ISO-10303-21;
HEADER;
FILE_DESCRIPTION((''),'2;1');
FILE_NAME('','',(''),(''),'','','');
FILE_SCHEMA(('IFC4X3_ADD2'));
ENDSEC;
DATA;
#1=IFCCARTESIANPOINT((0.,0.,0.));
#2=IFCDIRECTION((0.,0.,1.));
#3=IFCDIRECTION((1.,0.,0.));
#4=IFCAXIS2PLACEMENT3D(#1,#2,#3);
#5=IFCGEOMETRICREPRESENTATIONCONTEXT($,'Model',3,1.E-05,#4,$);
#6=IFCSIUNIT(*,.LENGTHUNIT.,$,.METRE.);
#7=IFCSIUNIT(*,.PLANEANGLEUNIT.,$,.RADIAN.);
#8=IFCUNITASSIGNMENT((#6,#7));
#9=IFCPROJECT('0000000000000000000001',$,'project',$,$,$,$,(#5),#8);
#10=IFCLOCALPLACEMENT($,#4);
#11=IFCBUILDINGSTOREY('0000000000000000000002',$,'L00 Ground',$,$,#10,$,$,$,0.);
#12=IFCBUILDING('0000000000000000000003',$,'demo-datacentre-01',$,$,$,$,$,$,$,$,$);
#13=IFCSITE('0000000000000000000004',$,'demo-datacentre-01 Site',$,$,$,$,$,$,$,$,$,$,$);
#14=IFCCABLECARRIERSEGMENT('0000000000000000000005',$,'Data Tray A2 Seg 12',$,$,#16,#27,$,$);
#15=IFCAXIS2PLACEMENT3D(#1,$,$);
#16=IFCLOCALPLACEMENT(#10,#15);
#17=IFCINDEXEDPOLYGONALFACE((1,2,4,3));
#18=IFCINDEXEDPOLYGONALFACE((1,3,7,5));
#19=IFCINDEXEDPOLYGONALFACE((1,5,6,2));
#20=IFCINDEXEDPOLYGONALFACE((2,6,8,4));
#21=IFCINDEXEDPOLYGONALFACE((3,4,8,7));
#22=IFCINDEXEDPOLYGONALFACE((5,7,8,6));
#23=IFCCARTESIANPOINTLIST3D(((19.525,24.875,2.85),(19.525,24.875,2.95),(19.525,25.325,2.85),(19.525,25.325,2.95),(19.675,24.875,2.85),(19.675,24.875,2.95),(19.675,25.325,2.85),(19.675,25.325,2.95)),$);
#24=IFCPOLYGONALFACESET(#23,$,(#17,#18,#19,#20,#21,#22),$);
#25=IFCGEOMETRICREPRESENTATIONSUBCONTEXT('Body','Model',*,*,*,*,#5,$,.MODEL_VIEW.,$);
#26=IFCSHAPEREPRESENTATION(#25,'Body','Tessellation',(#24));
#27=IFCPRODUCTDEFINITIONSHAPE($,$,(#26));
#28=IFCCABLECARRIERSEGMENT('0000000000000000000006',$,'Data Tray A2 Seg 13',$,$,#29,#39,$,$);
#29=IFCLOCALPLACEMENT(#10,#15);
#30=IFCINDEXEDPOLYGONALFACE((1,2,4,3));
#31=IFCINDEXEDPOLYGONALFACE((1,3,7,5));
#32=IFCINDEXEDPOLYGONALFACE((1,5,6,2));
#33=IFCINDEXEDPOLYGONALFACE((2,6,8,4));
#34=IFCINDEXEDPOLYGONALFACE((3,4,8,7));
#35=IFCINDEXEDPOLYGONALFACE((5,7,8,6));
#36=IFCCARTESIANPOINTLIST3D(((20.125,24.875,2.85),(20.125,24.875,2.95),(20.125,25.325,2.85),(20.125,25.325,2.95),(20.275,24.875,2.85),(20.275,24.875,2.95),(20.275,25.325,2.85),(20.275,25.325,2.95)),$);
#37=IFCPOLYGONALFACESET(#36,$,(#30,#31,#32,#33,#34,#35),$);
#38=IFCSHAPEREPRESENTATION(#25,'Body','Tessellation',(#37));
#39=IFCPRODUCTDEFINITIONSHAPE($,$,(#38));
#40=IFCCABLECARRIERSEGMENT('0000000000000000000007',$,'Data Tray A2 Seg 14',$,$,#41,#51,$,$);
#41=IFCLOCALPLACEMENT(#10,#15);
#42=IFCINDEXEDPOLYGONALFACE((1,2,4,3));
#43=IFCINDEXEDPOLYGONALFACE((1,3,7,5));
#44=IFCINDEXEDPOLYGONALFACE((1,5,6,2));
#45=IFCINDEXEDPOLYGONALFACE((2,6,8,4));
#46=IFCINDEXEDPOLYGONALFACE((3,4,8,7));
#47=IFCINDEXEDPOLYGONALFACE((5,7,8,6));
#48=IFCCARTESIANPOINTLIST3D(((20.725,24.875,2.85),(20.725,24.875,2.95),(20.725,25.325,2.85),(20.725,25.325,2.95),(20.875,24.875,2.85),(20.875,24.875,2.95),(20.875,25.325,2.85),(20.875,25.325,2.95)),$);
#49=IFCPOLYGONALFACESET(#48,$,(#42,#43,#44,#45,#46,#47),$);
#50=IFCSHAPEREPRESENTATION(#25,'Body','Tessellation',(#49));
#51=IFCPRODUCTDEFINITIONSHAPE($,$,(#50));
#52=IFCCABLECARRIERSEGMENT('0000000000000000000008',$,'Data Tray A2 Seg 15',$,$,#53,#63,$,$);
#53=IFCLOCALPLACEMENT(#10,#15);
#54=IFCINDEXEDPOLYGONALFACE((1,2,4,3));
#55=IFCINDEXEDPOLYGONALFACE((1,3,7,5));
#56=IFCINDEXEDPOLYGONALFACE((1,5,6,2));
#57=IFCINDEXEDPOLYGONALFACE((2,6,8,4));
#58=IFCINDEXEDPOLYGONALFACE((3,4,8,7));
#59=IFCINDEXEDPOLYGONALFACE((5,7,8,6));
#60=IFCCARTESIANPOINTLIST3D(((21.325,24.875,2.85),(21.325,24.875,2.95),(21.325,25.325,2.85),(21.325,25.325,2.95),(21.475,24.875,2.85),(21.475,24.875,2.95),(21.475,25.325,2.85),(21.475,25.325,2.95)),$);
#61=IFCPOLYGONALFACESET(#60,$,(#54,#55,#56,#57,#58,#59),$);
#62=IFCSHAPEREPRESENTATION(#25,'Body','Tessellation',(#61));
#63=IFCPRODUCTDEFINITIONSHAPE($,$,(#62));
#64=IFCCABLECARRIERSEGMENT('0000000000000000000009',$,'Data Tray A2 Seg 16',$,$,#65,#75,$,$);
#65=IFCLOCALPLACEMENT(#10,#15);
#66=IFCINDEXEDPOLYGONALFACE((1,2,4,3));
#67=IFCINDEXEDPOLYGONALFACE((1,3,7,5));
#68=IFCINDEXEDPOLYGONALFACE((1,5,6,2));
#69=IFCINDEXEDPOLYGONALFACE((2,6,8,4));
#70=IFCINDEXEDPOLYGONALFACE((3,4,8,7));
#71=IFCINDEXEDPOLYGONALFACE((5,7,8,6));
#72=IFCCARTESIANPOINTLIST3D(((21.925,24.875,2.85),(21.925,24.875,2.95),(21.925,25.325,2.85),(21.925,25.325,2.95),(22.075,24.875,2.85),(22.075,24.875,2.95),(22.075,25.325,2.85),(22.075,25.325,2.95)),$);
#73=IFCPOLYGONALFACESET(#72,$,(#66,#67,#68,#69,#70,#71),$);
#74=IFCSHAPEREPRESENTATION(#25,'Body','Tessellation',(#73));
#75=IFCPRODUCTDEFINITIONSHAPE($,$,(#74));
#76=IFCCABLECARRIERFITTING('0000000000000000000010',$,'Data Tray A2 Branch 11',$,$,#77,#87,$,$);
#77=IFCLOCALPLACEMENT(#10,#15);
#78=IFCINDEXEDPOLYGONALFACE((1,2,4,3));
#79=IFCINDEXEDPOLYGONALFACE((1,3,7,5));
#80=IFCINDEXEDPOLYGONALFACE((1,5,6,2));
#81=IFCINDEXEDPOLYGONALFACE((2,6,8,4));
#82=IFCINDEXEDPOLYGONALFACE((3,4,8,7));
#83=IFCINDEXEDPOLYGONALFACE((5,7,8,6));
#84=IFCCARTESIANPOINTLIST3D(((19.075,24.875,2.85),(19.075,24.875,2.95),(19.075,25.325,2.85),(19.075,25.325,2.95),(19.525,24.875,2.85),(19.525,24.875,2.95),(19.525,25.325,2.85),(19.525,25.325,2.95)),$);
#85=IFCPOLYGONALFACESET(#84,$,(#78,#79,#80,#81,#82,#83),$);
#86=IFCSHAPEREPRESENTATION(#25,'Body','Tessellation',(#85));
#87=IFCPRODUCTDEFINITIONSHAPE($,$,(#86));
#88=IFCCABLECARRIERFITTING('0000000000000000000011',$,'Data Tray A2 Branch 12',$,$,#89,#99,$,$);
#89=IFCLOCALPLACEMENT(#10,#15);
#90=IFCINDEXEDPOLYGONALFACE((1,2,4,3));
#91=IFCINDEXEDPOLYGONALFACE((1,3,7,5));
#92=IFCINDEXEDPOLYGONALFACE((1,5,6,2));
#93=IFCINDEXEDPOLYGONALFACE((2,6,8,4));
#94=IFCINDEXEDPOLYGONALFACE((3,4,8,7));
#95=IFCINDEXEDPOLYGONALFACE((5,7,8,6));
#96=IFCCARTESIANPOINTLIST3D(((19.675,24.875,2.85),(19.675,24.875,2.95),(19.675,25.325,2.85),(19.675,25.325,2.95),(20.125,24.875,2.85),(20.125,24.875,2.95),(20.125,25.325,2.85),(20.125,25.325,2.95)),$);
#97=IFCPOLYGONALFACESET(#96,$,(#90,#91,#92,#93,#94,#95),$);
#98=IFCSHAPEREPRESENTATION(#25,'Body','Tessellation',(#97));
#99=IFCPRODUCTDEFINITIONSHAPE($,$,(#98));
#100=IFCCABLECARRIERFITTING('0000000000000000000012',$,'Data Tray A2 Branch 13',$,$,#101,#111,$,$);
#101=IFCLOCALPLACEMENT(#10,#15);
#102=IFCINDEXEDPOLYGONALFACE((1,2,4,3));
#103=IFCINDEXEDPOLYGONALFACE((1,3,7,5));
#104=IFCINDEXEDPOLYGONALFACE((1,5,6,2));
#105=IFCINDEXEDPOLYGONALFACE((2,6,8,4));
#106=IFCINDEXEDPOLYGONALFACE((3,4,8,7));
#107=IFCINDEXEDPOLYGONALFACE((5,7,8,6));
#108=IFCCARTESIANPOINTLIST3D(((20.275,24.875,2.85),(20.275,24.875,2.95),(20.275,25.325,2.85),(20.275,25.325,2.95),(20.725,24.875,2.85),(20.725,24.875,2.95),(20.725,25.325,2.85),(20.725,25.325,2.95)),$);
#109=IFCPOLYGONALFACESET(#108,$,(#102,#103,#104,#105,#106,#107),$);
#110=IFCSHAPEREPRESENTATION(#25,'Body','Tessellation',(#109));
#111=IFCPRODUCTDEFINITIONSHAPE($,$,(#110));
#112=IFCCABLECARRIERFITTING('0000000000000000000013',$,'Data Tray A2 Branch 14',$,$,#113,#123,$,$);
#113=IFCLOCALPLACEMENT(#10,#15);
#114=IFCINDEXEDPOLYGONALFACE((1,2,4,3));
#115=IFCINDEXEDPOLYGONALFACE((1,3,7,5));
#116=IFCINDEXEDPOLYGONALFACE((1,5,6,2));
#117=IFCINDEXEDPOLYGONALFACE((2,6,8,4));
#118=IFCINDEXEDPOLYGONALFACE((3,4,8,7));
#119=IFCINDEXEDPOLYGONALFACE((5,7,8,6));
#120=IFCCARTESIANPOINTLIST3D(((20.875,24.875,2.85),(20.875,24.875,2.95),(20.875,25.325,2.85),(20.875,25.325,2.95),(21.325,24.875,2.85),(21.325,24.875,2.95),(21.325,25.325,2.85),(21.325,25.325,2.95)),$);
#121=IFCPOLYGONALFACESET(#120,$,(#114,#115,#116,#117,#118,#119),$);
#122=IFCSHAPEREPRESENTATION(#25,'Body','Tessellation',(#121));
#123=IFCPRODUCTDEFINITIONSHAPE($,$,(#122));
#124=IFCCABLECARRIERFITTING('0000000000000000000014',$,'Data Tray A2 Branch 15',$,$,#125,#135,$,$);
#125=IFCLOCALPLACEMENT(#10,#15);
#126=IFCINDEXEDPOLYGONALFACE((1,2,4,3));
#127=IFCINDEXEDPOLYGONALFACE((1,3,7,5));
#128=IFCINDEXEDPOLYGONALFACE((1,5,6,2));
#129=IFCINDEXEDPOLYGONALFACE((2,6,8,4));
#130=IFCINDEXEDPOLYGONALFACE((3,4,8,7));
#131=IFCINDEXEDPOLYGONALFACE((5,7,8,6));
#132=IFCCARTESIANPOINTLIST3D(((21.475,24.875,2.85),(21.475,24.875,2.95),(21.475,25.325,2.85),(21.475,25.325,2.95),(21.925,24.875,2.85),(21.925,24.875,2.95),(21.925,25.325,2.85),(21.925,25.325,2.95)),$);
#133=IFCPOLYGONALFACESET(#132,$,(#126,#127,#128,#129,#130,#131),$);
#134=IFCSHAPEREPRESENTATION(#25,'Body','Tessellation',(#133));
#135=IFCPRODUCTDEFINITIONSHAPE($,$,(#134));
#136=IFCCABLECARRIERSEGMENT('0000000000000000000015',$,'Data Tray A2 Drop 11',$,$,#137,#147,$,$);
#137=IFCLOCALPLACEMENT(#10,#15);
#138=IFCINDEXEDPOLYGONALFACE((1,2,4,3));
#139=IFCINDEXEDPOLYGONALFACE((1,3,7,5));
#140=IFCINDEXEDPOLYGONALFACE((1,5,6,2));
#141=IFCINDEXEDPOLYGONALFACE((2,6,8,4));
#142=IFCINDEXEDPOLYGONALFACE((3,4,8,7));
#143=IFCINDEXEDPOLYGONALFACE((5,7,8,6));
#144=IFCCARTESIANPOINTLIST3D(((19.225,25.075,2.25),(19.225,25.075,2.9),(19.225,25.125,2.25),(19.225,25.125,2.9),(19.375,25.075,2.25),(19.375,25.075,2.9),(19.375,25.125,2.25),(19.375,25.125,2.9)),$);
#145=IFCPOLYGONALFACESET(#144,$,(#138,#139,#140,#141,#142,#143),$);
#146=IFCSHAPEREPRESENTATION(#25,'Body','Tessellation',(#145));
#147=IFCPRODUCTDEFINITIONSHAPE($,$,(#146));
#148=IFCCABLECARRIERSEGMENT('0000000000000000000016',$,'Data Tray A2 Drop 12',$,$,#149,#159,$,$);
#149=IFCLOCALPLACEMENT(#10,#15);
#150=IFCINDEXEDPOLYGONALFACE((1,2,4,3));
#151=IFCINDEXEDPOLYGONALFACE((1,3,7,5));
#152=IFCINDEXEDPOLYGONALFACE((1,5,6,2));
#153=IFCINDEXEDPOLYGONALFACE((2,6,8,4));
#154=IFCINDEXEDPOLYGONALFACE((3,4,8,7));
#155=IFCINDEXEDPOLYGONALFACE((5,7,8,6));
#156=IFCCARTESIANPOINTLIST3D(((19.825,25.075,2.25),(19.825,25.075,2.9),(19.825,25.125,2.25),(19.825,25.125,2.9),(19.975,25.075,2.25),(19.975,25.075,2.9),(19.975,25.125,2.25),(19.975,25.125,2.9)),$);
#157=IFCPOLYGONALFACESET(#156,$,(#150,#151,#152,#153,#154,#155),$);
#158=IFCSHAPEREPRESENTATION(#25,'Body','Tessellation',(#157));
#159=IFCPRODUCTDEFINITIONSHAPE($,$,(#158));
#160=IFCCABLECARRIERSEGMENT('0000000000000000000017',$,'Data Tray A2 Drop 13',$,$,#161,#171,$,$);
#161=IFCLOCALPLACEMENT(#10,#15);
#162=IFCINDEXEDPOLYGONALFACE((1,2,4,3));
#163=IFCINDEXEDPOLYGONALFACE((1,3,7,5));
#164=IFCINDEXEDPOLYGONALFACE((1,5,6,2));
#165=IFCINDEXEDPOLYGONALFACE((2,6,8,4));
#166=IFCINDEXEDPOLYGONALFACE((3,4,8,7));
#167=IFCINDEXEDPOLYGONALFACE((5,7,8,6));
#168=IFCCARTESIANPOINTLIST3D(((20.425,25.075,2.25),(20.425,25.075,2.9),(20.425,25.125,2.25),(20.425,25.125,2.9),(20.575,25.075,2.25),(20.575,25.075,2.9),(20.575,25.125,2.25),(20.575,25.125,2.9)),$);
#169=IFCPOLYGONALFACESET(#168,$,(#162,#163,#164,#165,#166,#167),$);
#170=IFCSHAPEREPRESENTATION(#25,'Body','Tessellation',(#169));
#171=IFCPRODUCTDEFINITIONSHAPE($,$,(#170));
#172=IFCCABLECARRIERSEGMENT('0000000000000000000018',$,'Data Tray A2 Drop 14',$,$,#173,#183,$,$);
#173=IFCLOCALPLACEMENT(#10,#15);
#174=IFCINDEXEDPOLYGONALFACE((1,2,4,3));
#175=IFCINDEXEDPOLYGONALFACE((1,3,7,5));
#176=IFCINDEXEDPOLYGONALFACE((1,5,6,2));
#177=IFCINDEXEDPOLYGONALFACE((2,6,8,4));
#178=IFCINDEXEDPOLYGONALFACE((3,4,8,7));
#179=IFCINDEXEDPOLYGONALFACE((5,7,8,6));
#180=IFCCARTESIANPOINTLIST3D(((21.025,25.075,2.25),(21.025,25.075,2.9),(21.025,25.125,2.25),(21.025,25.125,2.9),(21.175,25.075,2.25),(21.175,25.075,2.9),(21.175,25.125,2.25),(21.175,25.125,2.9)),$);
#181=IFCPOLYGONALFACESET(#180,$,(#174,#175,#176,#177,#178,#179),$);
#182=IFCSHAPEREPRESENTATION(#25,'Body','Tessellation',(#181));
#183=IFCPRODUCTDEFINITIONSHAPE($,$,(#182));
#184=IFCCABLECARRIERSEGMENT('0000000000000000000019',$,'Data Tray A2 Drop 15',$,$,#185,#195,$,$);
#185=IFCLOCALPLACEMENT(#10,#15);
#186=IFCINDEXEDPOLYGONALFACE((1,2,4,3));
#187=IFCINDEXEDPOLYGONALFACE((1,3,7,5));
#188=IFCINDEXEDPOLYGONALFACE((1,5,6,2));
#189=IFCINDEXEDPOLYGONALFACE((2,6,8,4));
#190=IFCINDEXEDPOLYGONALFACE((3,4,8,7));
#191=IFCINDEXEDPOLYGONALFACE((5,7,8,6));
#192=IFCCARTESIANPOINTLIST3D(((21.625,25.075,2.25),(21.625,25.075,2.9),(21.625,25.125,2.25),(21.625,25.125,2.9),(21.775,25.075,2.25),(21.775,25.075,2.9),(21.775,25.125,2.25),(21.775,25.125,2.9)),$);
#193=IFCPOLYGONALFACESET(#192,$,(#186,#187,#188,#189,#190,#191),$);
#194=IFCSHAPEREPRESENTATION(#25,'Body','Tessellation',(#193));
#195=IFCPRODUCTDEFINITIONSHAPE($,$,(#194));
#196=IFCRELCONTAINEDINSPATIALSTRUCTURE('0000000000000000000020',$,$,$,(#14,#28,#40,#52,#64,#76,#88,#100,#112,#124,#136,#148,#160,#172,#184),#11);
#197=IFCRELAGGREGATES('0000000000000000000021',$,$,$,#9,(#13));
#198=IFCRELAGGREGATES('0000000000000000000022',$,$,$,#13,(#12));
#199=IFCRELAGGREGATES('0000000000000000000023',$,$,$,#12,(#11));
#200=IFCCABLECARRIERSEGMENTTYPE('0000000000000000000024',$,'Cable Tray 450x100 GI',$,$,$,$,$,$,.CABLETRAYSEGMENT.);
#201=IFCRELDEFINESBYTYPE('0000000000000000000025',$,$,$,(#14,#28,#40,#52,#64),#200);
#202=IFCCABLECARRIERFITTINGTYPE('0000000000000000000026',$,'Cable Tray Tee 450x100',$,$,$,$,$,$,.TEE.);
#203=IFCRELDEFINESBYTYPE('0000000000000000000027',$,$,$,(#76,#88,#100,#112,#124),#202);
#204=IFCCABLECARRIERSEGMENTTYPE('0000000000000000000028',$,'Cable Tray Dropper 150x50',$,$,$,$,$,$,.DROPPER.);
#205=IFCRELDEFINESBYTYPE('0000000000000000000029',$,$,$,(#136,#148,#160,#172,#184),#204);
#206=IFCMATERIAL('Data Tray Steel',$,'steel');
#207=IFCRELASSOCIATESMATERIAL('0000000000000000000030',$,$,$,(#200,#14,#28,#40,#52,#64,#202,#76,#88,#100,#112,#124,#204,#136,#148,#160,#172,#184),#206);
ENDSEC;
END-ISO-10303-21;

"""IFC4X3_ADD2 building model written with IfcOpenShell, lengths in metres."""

from ifc_helpers import new_model, si_unit, frame, origin_with_axes, place, context, subcontext, project, spatial, rectangle, extrude, material, type_object, element, save


model = new_model("IFC4X3_ADD2")

# Units and contexts
model_context = context("Model", 3, precision=1e-05, world=origin_with_axes())
body_context = subcontext(model_context, "Body", "Model", "MODEL_VIEW")
ifc_project = project(units=[si_unit("LENGTHUNIT", "METRE"), si_unit("PLANEANGLEUNIT", "RADIAN")], contexts=[model_context])

# Site, building, storey
site = spatial("IfcSite", under=ifc_project, Name="demo-datacentre-01 Site")
building = spatial("IfcBuilding", under=site, Name="demo-datacentre-01")
storey_placement = place(None, origin_with_axes())
storey = spatial("IfcBuildingStorey", under=building, at=storey_placement, Name="L00 Ground", Elevation=0.0)

# Cable carrier segments
ifc_material_1 = material(Name="Data Tray Steel", Category="steel")
cable_carrier_segment_type_1 = type_object("IfcCableCarrierSegmentType", Name="Cable Tray 450x100 GI", PredefinedType="CABLETRAYSEGMENT", material=ifc_material_1)
cable_carrier_segment_1_placement = place(storey_placement, frame((19.525, 25.1, 2.9), z_axis=(1.0, 0.0, 0.0), x_axis=(0.0, 1.0, 0.0)))
element("IfcCableCarrierSegment", 1, at=cable_carrier_segment_1_placement, inside=storey, type_object=cable_carrier_segment_type_1, material=ifc_material_1, Name="Data Tray A2 Seg 12", context=body_context, shape_type="SweptSolid", body=[
    extrude(rectangle(XDim=0.45, YDim=0.1), origin_with_axes(), (0.0, 0.0, 1.0), 0.15),
])
for number, where, z_axis, x_axis, name in (
    (2, (20.125, 25.1, 2.9), (1.0, 0.0, 0.0), (0.0, 1.0, 0.0), "Data Tray A2 Seg 13"),
    (3, (20.725, 25.1, 2.9), (1.0, 0.0, 0.0), (0.0, 1.0, 0.0), "Data Tray A2 Seg 14"),
    (4, (21.325, 25.1, 2.9), (1.0, 0.0, 0.0), (0.0, 1.0, 0.0), "Data Tray A2 Seg 15"),
):
    element("IfcCableCarrierSegment", number, at=place(storey_placement, frame(where, z_axis=z_axis, x_axis=x_axis)), inside=storey, type_object=cable_carrier_segment_type_1, material=ifc_material_1, Name=name, context=body_context, shape_type="SweptSolid", body=[
        extrude(rectangle(XDim=0.45, YDim=0.1), origin_with_axes(), (0.0, 0.0, 1.0), 0.15),
    ])
cable_carrier_segment_2_placement = place(storey_placement, frame((21.925, 25.1, 2.9), z_axis=(1.0, 0.0, 0.0), x_axis=(0.0, 1.0, 0.0)))
element("IfcCableCarrierSegment", 5, at=cable_carrier_segment_2_placement, inside=storey, type_object=cable_carrier_segment_type_1, material=ifc_material_1, Name="Data Tray A2 Seg 16", context=body_context, shape_type="SweptSolid", body=[
    extrude(rectangle(XDim=0.45, YDim=0.1), origin_with_axes(), (0.0, 0.0, 1.0), 0.15),
])

# Cable carrier fittings
cable_carrier_fitting_type = type_object("IfcCableCarrierFittingType", Name="Cable Tray Tee 450x100", PredefinedType="TEE", material=ifc_material_1)
for number, where, z_axis, x_axis, name in (
    (6, (19.3, 25.1, 2.85), (0.0, 0.0, 1.0), (1.0, 0.0, 0.0), "Data Tray A2 Branch 11"),
    (7, (19.9, 25.1, 2.85), (0.0, 0.0, 1.0), (1.0, 0.0, 0.0), "Data Tray A2 Branch 12"),
    (8, (20.5, 25.1, 2.85), (0.0, 0.0, 1.0), (1.0, 0.0, 0.0), "Data Tray A2 Branch 13"),
    (9, (21.1, 25.1, 2.85), (0.0, 0.0, 1.0), (1.0, 0.0, 0.0), "Data Tray A2 Branch 14"),
    (10, (21.7, 25.1, 2.85), (0.0, 0.0, 1.0), (1.0, 0.0, 0.0), "Data Tray A2 Branch 15"),
):
    element("IfcCableCarrierFitting", number, at=place(storey_placement, frame(where, z_axis=z_axis, x_axis=x_axis)), inside=storey, type_object=cable_carrier_fitting_type, material=ifc_material_1, Name=name, context=body_context, shape_type="SweptSolid", body=[
        extrude(rectangle(XDim=0.45, YDim=0.45), origin_with_axes(), (0.0, 0.0, 1.0), 0.1),
    ])

# Cable carrier segments
cable_carrier_segment_type_2 = type_object("IfcCableCarrierSegmentType", Name="Cable Tray Dropper 150x50", PredefinedType="DROPPER", material=ifc_material_1)
for number, where, z_axis, x_axis, name in (
    (11, (19.3, 25.1, 2.9), (0.0, 0.0, -1.0), (1.0, 0.0, 0.0), "Data Tray A2 Drop 11"),
    (12, (19.9, 25.1, 2.9), (0.0, 0.0, -1.0), (1.0, 0.0, 0.0), "Data Tray A2 Drop 12"),
    (13, (20.5, 25.1, 2.9), (0.0, 0.0, -1.0), (1.0, 0.0, 0.0), "Data Tray A2 Drop 13"),
    (14, (21.1, 25.1, 2.9), (0.0, 0.0, -1.0), (1.0, 0.0, 0.0), "Data Tray A2 Drop 14"),
    (15, (21.7, 25.1, 2.9), (0.0, 0.0, -1.0), (1.0, 0.0, 0.0), "Data Tray A2 Drop 15"),
):
    element("IfcCableCarrierSegment", number, at=place(storey_placement, frame(where, z_axis=z_axis, x_axis=x_axis)), inside=storey, type_object=cable_carrier_segment_type_2, material=ifc_material_1, Name=name, context=body_context, shape_type="SweptSolid", body=[
        extrude(rectangle(XDim=0.15, YDim=0.05), origin_with_axes(), (0.0, 0.0, 1.0), 0.65),
    ])

save(model, "model.ifc")
